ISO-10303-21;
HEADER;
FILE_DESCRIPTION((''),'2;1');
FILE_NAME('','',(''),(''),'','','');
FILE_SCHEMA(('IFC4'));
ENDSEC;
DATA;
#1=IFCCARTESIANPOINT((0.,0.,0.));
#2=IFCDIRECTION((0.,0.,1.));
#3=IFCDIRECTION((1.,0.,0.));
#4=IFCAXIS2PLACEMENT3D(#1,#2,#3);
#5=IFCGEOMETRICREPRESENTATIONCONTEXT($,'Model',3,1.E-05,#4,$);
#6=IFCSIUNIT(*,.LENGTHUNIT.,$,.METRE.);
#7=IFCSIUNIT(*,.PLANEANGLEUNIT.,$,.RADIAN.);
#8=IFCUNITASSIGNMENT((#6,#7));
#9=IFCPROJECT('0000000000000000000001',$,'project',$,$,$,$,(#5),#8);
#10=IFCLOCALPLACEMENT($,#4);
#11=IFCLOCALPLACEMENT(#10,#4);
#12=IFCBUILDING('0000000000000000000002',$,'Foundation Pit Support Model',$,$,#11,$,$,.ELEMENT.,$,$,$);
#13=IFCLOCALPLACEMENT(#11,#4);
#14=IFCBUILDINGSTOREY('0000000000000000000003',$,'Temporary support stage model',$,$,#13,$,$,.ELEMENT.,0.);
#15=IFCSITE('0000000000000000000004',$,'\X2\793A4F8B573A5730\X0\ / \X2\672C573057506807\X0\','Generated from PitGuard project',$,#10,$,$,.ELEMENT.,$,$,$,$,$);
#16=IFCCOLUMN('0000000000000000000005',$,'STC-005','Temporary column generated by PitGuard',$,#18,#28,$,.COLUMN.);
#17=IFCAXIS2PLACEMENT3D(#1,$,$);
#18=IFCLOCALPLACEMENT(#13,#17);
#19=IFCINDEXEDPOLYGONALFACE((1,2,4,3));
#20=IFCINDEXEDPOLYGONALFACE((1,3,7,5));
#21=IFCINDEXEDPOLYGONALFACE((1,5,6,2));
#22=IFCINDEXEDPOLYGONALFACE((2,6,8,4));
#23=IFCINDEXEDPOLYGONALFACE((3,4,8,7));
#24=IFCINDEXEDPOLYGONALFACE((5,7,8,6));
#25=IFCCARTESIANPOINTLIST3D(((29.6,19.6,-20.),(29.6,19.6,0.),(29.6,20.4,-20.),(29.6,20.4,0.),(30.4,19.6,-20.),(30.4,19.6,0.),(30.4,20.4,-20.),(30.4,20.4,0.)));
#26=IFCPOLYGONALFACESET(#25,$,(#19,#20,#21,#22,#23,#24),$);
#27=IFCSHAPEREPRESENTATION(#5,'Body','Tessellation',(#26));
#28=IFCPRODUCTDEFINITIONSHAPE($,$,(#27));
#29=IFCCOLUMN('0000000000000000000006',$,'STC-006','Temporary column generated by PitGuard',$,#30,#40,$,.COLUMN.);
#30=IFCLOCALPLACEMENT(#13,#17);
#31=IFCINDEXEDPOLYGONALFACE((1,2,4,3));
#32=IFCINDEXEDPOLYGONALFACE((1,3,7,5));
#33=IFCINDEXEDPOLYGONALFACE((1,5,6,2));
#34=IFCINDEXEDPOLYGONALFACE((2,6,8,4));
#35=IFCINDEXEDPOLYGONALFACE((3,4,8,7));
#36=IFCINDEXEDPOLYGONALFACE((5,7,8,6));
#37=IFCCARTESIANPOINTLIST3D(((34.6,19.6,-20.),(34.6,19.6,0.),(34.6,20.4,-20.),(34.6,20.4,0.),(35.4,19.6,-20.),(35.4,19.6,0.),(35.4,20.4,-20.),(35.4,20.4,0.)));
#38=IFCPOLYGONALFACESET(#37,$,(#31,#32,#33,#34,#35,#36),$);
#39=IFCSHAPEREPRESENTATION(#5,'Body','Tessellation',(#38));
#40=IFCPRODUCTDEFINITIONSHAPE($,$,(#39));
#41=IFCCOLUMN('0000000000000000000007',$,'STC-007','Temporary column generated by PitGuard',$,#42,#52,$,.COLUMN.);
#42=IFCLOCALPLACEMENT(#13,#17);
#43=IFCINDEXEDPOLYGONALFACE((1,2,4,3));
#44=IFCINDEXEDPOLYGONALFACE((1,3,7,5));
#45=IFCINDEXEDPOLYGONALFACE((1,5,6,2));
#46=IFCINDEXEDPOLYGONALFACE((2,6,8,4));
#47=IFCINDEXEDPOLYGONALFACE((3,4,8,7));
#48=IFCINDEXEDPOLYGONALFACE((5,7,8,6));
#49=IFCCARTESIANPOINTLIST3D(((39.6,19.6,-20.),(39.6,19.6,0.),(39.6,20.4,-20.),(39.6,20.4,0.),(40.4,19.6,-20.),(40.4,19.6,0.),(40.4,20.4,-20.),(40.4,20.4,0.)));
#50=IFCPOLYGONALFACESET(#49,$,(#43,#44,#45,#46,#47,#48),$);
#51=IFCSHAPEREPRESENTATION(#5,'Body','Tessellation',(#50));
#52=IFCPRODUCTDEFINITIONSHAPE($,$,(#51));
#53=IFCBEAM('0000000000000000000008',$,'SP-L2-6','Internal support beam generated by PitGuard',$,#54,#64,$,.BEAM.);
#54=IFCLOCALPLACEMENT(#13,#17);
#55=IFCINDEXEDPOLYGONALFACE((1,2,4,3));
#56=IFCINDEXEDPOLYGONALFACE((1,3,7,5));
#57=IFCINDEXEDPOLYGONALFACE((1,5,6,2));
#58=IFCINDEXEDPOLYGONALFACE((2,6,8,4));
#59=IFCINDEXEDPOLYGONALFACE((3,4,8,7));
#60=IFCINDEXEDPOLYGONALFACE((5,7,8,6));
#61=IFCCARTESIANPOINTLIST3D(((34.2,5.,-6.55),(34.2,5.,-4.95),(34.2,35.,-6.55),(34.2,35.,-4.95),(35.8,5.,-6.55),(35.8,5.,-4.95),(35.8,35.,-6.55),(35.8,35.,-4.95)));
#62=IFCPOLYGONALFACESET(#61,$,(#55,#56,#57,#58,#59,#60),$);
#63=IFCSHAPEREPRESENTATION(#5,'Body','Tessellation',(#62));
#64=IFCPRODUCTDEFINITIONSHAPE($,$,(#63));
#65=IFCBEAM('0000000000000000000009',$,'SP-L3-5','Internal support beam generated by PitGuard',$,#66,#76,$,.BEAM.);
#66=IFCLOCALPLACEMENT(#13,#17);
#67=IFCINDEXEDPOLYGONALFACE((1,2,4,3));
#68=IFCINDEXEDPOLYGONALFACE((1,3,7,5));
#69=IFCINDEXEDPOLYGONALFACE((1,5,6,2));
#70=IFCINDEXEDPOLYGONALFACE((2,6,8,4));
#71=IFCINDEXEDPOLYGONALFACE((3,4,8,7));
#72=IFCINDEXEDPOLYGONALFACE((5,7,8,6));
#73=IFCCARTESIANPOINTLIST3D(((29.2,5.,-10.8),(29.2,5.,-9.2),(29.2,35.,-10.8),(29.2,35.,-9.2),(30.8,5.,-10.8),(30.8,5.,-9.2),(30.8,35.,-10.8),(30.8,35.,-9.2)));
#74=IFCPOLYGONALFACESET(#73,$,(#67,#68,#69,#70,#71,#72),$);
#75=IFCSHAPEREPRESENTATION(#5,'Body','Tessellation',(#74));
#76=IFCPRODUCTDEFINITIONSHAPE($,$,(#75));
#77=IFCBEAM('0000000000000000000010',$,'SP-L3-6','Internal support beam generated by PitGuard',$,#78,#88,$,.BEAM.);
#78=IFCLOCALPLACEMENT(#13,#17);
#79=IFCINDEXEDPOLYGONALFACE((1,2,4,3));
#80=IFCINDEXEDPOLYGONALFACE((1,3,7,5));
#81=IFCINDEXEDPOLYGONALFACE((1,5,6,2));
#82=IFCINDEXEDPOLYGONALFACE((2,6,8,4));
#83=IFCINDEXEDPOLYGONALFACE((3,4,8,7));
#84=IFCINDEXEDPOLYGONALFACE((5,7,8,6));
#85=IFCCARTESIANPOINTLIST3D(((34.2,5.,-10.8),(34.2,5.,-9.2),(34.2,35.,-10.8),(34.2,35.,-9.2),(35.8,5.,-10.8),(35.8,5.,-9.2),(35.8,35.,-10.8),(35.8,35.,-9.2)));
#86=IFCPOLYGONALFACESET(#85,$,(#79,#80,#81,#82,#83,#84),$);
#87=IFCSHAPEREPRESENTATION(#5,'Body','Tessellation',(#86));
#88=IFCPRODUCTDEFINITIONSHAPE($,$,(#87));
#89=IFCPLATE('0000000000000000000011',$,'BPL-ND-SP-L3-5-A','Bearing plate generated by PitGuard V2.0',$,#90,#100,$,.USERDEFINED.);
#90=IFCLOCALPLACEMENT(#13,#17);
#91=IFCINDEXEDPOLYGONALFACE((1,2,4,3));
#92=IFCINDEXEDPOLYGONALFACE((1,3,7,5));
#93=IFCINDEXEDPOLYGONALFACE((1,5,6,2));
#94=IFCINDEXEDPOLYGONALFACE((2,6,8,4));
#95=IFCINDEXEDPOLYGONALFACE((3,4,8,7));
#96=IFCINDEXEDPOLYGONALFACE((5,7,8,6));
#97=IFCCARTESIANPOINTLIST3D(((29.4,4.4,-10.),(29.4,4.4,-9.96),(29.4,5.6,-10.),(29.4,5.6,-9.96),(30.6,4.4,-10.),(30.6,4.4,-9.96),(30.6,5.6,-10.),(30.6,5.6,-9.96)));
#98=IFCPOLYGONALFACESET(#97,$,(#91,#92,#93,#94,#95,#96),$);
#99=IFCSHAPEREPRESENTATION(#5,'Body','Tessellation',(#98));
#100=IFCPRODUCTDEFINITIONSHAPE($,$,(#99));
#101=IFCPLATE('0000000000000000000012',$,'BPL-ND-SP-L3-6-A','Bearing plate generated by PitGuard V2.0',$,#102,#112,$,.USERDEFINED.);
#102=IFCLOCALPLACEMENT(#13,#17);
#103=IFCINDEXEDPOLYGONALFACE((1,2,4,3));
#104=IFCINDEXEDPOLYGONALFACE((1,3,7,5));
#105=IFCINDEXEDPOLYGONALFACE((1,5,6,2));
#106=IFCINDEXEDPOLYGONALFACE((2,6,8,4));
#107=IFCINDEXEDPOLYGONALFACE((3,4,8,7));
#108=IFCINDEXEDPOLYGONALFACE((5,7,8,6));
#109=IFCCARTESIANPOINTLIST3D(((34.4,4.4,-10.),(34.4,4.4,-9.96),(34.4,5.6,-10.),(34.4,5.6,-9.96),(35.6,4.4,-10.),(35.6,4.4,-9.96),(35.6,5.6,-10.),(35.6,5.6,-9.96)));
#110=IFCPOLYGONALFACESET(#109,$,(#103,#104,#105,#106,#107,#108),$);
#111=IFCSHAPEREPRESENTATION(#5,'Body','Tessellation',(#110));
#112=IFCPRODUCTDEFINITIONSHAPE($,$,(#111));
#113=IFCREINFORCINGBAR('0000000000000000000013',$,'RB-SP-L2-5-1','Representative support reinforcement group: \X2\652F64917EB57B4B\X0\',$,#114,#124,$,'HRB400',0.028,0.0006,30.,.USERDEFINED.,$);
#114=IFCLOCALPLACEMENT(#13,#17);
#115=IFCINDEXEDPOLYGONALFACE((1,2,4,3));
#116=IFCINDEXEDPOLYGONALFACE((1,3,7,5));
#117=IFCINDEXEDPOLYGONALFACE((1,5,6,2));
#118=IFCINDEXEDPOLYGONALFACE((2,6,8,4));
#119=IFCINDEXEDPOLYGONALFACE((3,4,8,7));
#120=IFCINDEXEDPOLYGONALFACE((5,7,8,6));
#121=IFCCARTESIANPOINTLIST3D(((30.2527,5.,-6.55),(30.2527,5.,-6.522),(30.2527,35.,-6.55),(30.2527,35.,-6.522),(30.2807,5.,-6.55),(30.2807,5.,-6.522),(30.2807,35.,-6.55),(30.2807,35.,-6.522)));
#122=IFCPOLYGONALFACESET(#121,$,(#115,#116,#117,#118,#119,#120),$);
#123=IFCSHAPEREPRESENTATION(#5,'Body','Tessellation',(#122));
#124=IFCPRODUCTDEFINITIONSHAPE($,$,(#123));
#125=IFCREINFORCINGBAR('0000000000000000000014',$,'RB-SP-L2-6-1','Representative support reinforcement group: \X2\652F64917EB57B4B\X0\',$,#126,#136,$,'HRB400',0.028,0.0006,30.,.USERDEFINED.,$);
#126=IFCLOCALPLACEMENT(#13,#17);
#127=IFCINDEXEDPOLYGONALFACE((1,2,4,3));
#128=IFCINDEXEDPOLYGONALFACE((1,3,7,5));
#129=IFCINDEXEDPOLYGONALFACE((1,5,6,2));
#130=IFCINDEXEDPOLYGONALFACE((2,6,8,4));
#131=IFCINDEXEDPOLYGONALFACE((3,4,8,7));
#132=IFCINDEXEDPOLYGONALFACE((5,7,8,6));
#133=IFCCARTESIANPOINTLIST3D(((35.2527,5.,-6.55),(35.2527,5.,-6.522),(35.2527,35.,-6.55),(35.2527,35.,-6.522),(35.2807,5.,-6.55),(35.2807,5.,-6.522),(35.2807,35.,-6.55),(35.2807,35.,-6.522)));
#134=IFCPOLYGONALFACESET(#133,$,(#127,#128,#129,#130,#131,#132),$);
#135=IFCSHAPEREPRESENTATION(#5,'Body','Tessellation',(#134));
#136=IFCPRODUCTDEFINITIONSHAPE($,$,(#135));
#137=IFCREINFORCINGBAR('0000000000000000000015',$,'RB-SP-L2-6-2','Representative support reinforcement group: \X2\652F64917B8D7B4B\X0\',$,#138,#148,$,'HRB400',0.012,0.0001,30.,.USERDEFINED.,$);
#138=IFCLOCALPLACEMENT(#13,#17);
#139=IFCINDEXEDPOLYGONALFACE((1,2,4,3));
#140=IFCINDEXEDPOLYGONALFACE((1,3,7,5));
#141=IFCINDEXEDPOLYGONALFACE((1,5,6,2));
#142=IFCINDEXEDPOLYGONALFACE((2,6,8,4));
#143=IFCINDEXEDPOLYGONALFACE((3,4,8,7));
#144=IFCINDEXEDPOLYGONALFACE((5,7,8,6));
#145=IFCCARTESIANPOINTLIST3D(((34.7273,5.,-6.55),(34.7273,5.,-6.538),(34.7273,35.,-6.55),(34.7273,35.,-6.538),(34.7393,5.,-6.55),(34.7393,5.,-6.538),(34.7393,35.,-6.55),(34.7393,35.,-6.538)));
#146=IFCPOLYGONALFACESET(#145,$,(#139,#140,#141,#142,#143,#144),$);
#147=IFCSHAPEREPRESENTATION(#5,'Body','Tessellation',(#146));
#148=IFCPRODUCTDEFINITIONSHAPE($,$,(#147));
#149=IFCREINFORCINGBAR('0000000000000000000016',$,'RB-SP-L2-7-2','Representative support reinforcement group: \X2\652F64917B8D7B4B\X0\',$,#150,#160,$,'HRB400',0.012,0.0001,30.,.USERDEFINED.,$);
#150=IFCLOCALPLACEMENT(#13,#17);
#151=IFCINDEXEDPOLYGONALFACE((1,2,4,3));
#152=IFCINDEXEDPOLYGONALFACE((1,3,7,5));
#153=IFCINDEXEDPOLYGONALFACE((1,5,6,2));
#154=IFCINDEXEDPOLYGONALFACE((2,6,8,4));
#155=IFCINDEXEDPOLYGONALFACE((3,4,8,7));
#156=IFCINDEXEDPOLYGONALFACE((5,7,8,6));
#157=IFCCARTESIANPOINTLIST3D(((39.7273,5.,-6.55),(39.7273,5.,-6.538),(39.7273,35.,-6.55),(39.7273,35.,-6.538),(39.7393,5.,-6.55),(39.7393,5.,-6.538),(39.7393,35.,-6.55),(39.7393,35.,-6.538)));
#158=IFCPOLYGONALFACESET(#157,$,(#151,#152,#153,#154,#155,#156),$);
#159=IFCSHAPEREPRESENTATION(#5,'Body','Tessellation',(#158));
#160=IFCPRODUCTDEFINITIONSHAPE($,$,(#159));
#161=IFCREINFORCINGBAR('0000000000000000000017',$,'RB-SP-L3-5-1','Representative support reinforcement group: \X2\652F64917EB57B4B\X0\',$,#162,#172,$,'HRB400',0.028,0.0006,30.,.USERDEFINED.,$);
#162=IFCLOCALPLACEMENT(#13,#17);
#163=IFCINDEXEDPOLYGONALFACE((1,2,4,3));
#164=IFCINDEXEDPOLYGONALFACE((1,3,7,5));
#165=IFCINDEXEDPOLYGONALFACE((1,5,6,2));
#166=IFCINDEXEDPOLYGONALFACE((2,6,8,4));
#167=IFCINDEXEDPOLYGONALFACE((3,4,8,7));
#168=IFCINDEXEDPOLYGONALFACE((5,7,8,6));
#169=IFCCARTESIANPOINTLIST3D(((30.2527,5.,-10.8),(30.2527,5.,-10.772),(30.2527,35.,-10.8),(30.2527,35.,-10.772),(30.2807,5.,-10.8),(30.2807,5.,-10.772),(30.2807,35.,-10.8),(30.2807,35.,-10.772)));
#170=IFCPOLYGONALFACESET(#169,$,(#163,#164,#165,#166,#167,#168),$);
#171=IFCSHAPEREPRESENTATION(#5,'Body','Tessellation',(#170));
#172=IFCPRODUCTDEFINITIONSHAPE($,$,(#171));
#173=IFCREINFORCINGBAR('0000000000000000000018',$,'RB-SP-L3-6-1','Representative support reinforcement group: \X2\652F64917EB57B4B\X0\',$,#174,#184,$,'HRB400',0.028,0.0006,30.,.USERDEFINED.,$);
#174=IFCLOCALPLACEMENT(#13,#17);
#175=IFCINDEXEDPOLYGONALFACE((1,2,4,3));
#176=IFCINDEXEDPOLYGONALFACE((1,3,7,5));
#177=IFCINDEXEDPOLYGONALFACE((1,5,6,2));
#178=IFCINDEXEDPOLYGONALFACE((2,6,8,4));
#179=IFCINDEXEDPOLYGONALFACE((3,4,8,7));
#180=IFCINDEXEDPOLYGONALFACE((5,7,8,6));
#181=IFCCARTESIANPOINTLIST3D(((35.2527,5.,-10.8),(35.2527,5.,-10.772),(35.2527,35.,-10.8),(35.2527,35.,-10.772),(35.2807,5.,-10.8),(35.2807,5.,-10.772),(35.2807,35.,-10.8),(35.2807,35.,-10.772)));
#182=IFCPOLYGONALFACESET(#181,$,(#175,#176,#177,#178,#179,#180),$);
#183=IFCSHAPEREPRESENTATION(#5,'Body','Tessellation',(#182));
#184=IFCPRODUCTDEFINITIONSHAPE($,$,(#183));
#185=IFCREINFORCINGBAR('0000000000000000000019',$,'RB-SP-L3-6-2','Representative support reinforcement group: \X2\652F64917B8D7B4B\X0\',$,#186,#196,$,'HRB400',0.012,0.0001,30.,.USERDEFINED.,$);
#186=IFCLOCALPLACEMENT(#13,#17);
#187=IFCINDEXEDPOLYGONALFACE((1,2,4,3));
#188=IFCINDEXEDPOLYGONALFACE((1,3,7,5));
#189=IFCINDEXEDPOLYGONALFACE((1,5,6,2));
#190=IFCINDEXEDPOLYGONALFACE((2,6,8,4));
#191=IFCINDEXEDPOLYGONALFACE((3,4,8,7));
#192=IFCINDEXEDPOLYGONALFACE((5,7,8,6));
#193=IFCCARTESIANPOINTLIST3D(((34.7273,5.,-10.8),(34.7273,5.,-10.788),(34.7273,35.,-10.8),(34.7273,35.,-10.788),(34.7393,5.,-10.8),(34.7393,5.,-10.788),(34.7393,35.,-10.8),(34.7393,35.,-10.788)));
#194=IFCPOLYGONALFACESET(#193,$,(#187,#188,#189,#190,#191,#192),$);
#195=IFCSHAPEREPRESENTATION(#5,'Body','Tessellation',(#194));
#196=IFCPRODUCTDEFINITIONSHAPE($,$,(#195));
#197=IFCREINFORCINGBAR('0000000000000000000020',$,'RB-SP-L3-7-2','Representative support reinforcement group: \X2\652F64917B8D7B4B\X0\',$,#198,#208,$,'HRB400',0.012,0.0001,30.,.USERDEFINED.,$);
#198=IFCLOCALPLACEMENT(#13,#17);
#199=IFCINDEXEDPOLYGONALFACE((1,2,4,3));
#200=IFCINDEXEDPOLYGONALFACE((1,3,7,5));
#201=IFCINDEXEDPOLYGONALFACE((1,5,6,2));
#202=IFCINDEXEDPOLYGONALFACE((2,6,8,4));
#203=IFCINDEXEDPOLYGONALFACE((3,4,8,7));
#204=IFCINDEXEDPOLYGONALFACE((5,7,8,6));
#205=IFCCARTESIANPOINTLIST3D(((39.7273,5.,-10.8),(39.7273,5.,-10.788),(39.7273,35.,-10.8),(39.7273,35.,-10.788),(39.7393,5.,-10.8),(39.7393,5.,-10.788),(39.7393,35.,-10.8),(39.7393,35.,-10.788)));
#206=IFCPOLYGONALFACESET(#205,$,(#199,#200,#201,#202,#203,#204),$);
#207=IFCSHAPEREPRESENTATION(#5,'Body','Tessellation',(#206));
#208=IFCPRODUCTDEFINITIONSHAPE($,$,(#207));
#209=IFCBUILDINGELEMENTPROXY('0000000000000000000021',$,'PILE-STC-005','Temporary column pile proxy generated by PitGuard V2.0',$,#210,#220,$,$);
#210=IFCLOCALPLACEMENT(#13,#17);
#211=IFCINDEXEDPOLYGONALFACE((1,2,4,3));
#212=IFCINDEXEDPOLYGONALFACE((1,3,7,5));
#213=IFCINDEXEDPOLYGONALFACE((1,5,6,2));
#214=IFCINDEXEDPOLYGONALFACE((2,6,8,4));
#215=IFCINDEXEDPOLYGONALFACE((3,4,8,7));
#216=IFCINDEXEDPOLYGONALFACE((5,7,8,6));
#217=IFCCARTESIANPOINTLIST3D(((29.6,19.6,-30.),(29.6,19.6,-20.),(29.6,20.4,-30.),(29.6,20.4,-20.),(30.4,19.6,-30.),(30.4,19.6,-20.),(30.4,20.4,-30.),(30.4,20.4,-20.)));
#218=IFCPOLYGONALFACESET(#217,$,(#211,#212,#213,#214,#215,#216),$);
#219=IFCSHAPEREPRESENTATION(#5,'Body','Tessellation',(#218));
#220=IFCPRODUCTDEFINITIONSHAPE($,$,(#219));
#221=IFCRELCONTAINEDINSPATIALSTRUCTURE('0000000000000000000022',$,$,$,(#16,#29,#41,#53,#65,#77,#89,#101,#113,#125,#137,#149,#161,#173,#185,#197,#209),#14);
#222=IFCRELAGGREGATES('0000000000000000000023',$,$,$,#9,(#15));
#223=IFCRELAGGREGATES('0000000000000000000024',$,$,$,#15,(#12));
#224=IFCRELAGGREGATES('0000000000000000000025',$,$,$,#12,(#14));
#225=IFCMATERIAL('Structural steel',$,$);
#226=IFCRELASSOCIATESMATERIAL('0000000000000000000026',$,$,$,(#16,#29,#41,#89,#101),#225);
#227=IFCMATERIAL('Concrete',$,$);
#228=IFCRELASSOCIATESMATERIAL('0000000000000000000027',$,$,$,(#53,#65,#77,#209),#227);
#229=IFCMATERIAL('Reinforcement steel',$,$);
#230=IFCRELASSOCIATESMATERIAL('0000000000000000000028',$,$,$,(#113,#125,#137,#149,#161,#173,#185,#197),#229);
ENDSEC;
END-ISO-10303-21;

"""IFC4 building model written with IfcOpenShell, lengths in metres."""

from ifc_helpers import new_model, si_unit, frame, origin_with_axes, origin_2d, place, context, project, spatial, rectangle, extrude, material, element, save


model = new_model("IFC4")

# Units and contexts
model_context = context("Model", 3, precision=1e-05, world=origin_with_axes())
ifc_project = project(units=[si_unit("LENGTHUNIT", "METRE"), si_unit("PLANEANGLEUNIT", "RADIAN")], contexts=[model_context])

# Site, building, storey
site_placement = place(None, origin_with_axes())
site = spatial("IfcSite", under=ifc_project, at=site_placement, Name="示例场地 / 本地坐标", Description="Generated from PitGuard project", CompositionType="ELEMENT")
building_placement = place(site_placement, origin_with_axes())
building = spatial("IfcBuilding", under=site, at=building_placement, Name="Foundation Pit Support Model", CompositionType="ELEMENT")
storey_placement = place(building_placement, origin_with_axes())
storey = spatial("IfcBuildingStorey", under=building, at=storey_placement, Name="Temporary support stage model", CompositionType="ELEMENT", Elevation=0.0)

# Columns
ifc_material_1 = material(Name="Structural steel")
for number, where, z_axis, x_axis, name in (
    (1, (30.0, 20.0, -20.0), (0.0, 0.0, 1.0), (1.0, 0.0, 0.0), "STC-005"),
    (2, (35.0, 20.0, -20.0), (0.0, 0.0, 1.0), (1.0, 0.0, 0.0), "STC-006"),
    (3, (40.0, 20.0, -20.0), (0.0, 0.0, 1.0), (1.0, 0.0, 0.0), "STC-007"),
):
    element("IfcColumn", number, at=place(storey_placement, frame(where, z_axis=z_axis, x_axis=x_axis)), inside=storey, material=ifc_material_1, Name=name, Description="Temporary column generated by PitGuard", PredefinedType="COLUMN", context=model_context, shape_type="SweptSolid", body=[
        extrude(rectangle(XDim=0.8, YDim=0.8, at=origin_2d()), origin_with_axes(), (0.0, 0.0, 1.0), 20.0),
    ])

# Beams
ifc_material_2 = material(Name="Concrete")
for number, where, z_axis, x_axis, name in (
    (4, (35.0, 20.0, -6.55), (0.0, 0.0, 1.0), (0.0, 1.0, 0.0), "SP-L2-6"),
    (5, (30.0, 20.0, -10.8), (0.0, 0.0, 1.0), (0.0, 1.0, 0.0), "SP-L3-5"),
    (6, (35.0, 20.0, -10.8), (0.0, 0.0, 1.0), (0.0, 1.0, 0.0), "SP-L3-6"),
):
    element("IfcBeam", number, at=place(storey_placement, frame(where, z_axis=z_axis, x_axis=x_axis)), inside=storey, material=ifc_material_2, Name=name, Description="Internal support beam generated by PitGuard", PredefinedType="BEAM", context=model_context, shape_type="SweptSolid", body=[
        extrude(rectangle(XDim=30.0, YDim=1.6, at=origin_2d()), origin_with_axes(), (0.0, 0.0, 1.0), 1.6),
    ])

# Plates
for number, where, z_axis, x_axis, name in (
    (7, (30.0, 5.0, -10.0), (0.0, 0.0, 1.0), (1.0, 0.0, 0.0), "BPL-ND-SP-L3-5-A"),
    (8, (35.0, 5.0, -10.0), (0.0, 0.0, 1.0), (1.0, 0.0, 0.0), "BPL-ND-SP-L3-6-A"),
):
    element("IfcPlate", number, at=place(storey_placement, frame(where, z_axis=z_axis, x_axis=x_axis)), inside=storey, material=ifc_material_1, Name=name, Description="Bearing plate generated by PitGuard V2.0", PredefinedType="USERDEFINED", context=model_context, shape_type="SweptSolid", body=[
        extrude(rectangle(XDim=1.2, YDim=1.2, at=origin_2d()), origin_with_axes(), (0.0, 0.0, 1.0), 0.04),
    ])

# Reinforcing bars
ifc_material_3 = material(Name="Reinforcement steel")
for number, where, z_axis, x_axis, name in (
    (9, (30.2667, 20.0, -6.55), (0.0, 0.0, 1.0), (0.0, 1.0, 0.0), "RB-SP-L2-5-1"),
    (10, (35.2667, 20.0, -6.55), (0.0, 0.0, 1.0), (0.0, 1.0, 0.0), "RB-SP-L2-6-1"),
):
    element("IfcReinforcingBar", number, at=place(storey_placement, frame(where, z_axis=z_axis, x_axis=x_axis)), inside=storey, material=ifc_material_3, Name=name, Description="Representative support reinforcement group: 支撑纵筋", SteelGrade="HRB400", BarLength=30.0, CrossSectionArea=0.0006, NominalDiameter=0.028, PredefinedType="USERDEFINED", context=model_context, shape_type="SweptSolid", body=[
        extrude(rectangle(XDim=30.0, YDim=0.028, at=origin_2d()), origin_with_axes(), (0.0, 0.0, 1.0), 0.028),
    ])
for number, where, z_axis, x_axis, name in (
    (11, (34.7333, 20.0, -6.55), (0.0, 0.0, 1.0), (0.0, 1.0, 0.0), "RB-SP-L2-6-2"),
    (12, (39.7333, 20.0, -6.55), (0.0, 0.0, 1.0), (0.0, 1.0, 0.0), "RB-SP-L2-7-2"),
):
    element("IfcReinforcingBar", number, at=place(storey_placement, frame(where, z_axis=z_axis, x_axis=x_axis)), inside=storey, material=ifc_material_3, Name=name, Description="Representative support reinforcement group: 支撑箍筋", SteelGrade="HRB400", BarLength=30.0, CrossSectionArea=0.0001, NominalDiameter=0.012, PredefinedType="USERDEFINED", context=model_context, shape_type="SweptSolid", body=[
        extrude(rectangle(XDim=30.0, YDim=0.012, at=origin_2d()), origin_with_axes(), (0.0, 0.0, 1.0), 0.012),
    ])
for number, where, z_axis, x_axis, name in (
    (13, (30.2667, 20.0, -10.8), (0.0, 0.0, 1.0), (0.0, 1.0, 0.0), "RB-SP-L3-5-1"),
    (14, (35.2667, 20.0, -10.8), (0.0, 0.0, 1.0), (0.0, 1.0, 0.0), "RB-SP-L3-6-1"),
):
    element("IfcReinforcingBar", number, at=place(storey_placement, frame(where, z_axis=z_axis, x_axis=x_axis)), inside=storey, material=ifc_material_3, Name=name, Description="Representative support reinforcement group: 支撑纵筋", SteelGrade="HRB400", BarLength=30.0, CrossSectionArea=0.0006, NominalDiameter=0.028, PredefinedType="USERDEFINED", context=model_context, shape_type="SweptSolid", body=[
        extrude(rectangle(XDim=30.0, YDim=0.028, at=origin_2d()), origin_with_axes(), (0.0, 0.0, 1.0), 0.028),
    ])
for number, where, z_axis, x_axis, name in (
    (15, (34.7333, 20.0, -10.8), (0.0, 0.0, 1.0), (0.0, 1.0, 0.0), "RB-SP-L3-6-2"),
    (16, (39.7333, 20.0, -10.8), (0.0, 0.0, 1.0), (0.0, 1.0, 0.0), "RB-SP-L3-7-2"),
):
    element("IfcReinforcingBar", number, at=place(storey_placement, frame(where, z_axis=z_axis, x_axis=x_axis)), inside=storey, material=ifc_material_3, Name=name, Description="Representative support reinforcement group: 支撑箍筋", SteelGrade="HRB400", BarLength=30.0, CrossSectionArea=0.0001, NominalDiameter=0.012, PredefinedType="USERDEFINED", context=model_context, shape_type="SweptSolid", body=[
        extrude(rectangle(XDim=30.0, YDim=0.012, at=origin_2d()), origin_with_axes(), (0.0, 0.0, 1.0), 0.012),
    ])

# Building element proxy
for number, where, z_axis, x_axis, name in (
    (17, (30.0, 20.0, -30.0), (0.0, 0.0, 1.0), (1.0, 0.0, 0.0), "PILE-STC-005"),
):
    element("IfcBuildingElementProxy", number, at=place(storey_placement, frame(where, z_axis=z_axis, x_axis=x_axis)), inside=storey, material=ifc_material_2, Name=name, Description="Temporary column pile proxy generated by PitGuard V2.0", context=model_context, shape_type="SweptSolid", body=[
        extrude(rectangle(XDim=0.8, YDim=0.8, at=origin_2d()), origin_with_axes(), (0.0, 0.0, 1.0), 10.0),
    ])

save(model, "model.ifc")
